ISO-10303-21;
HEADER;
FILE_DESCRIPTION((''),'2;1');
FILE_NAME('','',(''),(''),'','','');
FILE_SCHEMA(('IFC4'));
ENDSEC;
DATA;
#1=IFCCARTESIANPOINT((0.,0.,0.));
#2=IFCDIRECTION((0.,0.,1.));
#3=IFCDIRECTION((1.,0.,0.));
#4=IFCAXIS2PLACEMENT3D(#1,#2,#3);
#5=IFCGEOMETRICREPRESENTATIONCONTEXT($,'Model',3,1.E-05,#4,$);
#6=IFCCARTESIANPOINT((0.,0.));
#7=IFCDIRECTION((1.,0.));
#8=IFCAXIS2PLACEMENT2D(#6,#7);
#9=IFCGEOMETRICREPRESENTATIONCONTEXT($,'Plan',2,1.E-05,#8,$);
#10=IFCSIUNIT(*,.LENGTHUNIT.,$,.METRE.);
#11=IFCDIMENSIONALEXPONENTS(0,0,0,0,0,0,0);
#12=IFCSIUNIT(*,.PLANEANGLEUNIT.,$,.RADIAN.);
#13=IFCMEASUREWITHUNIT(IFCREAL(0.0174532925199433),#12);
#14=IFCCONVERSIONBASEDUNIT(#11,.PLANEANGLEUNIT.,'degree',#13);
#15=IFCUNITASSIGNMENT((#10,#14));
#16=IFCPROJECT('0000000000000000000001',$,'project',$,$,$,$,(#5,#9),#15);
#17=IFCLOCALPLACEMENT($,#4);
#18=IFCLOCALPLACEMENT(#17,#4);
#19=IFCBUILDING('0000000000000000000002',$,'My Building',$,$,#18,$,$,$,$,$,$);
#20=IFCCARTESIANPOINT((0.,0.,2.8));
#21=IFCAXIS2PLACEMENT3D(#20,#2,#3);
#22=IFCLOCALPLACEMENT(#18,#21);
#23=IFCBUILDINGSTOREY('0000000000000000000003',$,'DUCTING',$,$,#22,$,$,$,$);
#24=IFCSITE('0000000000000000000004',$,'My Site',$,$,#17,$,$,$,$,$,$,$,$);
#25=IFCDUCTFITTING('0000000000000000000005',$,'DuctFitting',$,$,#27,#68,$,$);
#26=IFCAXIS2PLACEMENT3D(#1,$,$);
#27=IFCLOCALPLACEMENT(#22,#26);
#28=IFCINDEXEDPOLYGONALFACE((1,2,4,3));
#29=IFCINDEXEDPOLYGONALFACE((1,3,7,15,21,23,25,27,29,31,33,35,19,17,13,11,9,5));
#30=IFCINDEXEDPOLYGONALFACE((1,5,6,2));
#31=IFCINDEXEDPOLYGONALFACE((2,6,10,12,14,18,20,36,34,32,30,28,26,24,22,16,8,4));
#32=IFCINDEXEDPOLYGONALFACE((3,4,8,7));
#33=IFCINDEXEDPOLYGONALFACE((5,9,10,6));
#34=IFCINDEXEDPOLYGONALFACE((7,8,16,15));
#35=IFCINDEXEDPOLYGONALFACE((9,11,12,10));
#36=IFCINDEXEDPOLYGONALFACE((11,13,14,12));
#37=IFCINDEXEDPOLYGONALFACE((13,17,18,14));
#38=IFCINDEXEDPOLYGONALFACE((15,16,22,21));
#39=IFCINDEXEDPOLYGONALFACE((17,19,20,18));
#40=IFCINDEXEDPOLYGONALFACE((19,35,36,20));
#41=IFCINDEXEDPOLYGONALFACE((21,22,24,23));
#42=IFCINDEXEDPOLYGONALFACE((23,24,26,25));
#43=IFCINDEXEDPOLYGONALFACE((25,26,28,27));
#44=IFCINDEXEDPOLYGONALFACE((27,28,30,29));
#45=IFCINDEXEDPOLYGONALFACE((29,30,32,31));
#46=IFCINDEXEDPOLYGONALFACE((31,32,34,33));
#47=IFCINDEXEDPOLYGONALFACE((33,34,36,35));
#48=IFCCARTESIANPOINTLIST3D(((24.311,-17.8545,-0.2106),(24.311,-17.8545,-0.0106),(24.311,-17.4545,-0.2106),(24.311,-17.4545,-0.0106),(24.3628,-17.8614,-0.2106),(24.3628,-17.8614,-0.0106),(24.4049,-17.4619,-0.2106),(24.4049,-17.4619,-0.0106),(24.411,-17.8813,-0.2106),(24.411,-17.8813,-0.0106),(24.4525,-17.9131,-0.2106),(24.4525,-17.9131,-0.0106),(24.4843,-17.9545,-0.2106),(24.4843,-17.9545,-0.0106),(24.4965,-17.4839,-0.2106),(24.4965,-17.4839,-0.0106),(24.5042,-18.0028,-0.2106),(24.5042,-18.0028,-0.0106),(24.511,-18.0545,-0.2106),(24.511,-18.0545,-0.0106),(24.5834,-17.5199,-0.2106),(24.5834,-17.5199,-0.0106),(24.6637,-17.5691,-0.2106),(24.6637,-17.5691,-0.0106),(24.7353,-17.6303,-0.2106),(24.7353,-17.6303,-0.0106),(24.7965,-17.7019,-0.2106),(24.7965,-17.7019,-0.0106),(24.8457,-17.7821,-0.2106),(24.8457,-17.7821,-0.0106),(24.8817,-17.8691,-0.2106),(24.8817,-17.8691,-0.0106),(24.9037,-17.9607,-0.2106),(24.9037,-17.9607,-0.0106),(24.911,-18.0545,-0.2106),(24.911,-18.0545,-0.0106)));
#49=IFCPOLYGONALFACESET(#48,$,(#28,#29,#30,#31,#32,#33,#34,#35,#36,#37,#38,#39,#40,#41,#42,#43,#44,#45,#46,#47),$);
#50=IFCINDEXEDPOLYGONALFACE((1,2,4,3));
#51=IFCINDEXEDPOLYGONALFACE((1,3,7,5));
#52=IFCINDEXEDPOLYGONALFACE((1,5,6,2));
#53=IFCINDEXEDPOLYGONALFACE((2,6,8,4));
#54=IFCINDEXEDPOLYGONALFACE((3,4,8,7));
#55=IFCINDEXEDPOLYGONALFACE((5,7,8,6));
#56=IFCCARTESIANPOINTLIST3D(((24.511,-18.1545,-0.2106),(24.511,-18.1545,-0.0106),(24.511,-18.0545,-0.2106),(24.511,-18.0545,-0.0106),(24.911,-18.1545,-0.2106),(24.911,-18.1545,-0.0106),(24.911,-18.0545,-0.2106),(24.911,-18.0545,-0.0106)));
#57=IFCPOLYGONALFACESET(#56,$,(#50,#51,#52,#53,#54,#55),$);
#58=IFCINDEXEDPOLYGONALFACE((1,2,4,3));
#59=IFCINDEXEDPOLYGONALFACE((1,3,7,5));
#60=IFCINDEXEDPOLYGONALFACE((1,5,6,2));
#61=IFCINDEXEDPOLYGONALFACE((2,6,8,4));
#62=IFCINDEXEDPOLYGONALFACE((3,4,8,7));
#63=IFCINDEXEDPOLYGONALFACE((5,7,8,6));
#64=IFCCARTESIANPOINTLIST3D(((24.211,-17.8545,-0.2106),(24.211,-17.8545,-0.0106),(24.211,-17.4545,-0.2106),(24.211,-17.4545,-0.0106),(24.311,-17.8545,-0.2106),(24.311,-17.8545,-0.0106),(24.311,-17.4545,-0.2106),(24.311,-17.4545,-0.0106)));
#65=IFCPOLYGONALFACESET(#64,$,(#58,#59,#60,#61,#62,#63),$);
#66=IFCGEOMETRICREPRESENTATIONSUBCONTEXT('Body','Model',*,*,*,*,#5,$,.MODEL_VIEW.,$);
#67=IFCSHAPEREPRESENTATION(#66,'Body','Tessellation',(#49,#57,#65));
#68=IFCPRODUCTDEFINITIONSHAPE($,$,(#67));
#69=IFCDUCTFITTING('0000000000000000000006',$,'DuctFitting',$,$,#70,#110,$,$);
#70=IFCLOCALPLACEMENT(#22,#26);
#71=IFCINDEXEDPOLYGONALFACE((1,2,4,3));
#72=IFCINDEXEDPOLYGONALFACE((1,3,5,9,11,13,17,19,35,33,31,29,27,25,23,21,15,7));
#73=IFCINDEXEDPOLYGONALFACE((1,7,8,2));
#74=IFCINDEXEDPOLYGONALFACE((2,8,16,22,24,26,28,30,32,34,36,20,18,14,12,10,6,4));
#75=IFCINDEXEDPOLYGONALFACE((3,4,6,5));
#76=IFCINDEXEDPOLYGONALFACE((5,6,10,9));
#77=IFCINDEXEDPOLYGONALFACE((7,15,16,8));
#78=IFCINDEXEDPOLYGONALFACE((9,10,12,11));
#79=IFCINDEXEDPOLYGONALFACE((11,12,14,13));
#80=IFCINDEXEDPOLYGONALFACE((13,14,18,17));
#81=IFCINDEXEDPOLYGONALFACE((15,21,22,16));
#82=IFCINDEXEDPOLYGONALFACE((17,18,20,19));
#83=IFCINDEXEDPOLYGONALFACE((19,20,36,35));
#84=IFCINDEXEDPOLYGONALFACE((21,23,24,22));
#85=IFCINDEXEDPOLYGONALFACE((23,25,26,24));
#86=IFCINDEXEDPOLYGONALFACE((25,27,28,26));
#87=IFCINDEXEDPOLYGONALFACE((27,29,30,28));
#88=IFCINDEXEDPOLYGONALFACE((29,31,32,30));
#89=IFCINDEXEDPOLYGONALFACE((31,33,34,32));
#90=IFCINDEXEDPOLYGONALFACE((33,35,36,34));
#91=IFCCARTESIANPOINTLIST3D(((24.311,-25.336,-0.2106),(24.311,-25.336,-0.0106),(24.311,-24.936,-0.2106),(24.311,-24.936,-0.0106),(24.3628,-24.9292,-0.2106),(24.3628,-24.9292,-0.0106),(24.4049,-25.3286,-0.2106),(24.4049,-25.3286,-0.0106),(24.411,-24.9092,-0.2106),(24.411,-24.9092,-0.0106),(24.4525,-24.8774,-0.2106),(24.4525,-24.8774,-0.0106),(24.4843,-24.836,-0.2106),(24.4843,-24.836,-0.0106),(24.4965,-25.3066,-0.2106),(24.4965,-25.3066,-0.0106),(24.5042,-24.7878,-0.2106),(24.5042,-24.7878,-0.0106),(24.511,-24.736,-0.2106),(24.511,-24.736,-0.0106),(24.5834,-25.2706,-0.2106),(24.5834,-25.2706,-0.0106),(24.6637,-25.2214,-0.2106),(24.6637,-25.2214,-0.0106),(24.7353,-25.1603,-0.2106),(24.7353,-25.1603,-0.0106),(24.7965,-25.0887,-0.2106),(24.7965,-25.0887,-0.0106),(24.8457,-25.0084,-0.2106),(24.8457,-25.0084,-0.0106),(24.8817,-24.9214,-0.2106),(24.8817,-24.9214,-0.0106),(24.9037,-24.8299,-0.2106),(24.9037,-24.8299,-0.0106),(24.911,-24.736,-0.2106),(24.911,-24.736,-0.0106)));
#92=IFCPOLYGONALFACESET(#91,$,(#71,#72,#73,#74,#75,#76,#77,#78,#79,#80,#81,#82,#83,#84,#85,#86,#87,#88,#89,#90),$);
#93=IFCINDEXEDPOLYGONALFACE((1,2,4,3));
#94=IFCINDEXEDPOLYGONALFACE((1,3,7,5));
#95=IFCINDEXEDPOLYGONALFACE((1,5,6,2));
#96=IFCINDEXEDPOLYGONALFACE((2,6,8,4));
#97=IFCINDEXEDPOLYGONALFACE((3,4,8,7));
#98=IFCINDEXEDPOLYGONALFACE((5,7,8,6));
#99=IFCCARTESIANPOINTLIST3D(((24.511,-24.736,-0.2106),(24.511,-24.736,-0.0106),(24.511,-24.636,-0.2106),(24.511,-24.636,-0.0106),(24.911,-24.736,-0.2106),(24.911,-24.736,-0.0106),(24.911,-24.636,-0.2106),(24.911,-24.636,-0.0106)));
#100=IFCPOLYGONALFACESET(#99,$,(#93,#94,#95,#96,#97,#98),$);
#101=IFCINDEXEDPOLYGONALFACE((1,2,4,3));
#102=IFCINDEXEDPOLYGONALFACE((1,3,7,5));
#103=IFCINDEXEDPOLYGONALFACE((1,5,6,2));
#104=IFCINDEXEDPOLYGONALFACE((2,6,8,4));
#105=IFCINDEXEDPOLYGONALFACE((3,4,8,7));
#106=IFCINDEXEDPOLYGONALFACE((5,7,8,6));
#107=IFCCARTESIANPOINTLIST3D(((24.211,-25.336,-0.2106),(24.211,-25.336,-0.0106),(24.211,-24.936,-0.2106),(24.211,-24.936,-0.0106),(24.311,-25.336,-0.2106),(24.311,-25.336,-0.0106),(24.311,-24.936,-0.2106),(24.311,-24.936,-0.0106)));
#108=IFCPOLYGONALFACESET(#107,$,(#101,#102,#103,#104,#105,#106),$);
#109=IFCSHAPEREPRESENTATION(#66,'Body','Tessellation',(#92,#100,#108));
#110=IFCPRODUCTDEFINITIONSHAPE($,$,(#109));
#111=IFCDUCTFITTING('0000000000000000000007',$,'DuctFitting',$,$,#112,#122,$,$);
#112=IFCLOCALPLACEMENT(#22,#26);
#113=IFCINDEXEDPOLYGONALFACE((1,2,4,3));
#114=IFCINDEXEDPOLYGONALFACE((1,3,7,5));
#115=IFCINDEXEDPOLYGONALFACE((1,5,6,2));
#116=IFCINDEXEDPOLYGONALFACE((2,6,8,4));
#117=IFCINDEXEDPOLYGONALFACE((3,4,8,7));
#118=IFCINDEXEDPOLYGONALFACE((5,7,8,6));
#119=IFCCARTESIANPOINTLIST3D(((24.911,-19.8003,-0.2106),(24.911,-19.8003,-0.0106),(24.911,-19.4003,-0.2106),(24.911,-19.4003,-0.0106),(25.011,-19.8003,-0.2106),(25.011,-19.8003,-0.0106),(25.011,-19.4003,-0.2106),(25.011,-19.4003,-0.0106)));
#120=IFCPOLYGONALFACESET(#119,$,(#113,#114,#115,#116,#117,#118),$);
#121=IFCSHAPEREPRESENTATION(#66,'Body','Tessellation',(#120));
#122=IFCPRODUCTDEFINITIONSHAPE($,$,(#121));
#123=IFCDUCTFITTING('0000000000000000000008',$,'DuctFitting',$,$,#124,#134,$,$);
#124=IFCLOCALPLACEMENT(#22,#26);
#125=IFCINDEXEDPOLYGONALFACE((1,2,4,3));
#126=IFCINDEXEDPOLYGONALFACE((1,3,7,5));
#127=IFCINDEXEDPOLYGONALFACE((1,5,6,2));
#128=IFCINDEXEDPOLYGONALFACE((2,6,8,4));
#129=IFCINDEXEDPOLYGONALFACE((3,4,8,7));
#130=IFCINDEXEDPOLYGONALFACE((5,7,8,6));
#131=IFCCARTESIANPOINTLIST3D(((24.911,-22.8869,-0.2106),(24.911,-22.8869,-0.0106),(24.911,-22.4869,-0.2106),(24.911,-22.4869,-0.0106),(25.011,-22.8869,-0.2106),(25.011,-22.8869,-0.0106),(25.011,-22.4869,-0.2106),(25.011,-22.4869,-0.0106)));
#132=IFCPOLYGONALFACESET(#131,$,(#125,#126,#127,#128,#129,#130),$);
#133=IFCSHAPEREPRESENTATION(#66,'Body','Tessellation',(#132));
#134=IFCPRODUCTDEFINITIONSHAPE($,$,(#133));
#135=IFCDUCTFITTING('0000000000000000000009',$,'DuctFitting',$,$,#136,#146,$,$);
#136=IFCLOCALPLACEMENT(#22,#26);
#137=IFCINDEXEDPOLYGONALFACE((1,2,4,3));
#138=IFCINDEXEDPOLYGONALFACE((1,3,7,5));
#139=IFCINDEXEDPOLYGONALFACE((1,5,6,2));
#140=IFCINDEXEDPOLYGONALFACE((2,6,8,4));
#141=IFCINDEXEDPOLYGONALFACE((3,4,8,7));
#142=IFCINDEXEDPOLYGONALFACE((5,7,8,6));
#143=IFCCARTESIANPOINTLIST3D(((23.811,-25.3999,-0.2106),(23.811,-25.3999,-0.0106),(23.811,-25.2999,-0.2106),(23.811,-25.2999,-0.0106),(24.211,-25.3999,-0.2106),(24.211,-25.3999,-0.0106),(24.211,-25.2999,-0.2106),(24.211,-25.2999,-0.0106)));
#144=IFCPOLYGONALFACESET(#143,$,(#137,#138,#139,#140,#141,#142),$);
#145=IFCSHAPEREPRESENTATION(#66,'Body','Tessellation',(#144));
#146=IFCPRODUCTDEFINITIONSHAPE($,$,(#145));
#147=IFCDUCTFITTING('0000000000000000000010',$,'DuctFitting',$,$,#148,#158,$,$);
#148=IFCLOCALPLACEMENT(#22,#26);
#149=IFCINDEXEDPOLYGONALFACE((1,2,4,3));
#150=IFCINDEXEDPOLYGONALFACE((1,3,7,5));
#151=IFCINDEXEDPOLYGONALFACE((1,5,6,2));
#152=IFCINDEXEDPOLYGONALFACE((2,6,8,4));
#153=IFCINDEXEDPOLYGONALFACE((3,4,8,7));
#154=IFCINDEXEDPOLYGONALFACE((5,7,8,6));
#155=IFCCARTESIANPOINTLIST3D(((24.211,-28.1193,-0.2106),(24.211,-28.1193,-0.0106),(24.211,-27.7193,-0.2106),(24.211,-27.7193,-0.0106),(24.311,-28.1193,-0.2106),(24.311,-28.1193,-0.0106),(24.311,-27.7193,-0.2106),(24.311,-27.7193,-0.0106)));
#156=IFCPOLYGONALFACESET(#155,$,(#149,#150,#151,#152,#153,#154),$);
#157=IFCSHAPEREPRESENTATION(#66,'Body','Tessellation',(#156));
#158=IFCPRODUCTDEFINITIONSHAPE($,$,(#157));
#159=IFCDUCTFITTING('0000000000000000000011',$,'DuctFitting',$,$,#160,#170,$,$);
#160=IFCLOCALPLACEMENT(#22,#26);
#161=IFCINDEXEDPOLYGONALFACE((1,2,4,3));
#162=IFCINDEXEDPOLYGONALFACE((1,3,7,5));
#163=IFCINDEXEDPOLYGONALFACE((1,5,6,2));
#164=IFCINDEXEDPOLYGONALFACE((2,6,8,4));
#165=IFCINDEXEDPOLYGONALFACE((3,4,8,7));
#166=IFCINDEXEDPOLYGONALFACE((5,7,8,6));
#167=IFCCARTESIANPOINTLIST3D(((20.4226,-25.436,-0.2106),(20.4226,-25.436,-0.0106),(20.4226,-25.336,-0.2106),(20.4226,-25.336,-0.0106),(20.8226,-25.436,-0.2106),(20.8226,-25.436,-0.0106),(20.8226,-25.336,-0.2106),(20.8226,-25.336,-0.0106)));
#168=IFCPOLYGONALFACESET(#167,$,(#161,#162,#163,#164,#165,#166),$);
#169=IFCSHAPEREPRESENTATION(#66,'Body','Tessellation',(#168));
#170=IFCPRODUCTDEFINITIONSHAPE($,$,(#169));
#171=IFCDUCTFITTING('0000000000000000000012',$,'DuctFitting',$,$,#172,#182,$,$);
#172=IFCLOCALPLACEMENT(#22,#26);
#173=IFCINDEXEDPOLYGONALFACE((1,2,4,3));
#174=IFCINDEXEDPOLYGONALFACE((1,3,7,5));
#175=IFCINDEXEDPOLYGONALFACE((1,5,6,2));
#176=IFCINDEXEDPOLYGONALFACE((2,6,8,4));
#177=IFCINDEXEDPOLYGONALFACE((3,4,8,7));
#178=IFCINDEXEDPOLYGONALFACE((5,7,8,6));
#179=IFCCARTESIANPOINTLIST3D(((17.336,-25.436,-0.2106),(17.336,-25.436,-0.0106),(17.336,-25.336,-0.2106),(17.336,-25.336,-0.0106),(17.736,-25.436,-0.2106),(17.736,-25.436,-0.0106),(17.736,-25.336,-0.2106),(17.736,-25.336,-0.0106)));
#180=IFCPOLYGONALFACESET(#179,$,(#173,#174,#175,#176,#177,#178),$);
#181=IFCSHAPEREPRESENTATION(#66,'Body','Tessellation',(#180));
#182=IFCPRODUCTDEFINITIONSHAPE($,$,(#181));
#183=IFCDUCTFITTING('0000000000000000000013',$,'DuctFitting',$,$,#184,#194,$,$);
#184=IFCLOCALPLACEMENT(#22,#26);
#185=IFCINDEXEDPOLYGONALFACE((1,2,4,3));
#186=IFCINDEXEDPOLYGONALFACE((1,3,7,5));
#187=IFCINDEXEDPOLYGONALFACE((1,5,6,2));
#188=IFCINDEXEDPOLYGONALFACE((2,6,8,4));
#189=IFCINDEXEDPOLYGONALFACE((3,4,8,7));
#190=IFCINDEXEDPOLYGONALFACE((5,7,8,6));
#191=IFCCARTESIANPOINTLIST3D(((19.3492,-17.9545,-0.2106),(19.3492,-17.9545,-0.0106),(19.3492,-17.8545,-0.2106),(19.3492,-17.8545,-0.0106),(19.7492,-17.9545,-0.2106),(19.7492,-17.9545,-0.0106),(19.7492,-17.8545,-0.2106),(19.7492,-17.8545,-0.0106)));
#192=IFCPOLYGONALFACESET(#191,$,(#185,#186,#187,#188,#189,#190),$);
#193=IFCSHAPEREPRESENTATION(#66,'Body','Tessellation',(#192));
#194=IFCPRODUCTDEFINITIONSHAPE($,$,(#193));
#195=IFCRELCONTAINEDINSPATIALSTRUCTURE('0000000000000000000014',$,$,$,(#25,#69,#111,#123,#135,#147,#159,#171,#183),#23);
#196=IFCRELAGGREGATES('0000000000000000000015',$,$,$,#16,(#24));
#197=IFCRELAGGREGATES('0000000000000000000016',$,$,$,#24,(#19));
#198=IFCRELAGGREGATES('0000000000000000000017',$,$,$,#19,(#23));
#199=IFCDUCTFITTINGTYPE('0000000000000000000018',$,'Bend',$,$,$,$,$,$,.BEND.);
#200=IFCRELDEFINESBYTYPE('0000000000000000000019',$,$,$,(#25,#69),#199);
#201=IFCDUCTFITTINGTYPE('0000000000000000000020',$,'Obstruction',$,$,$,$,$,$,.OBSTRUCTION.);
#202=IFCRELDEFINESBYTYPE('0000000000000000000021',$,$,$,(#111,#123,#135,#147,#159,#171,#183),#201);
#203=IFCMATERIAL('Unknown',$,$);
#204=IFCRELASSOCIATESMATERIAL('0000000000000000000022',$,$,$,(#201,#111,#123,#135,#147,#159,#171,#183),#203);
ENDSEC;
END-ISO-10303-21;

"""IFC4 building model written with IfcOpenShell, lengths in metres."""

from ifc_helpers import new_model, entity, si_unit, converted_unit, frame, origin_with_axes, origin_2d_with_axis, place, context, subcontext, project, spatial, line, arc, indexed_curve, rectangle, outline, extrude, source, transform, mapped, material, material_profile, profile_set, profile_usage, type_object, type_shapes, element, save


model = new_model("IFC4")

# Units and contexts
model_context = context("Model", 3, precision=1e-05, world=origin_with_axes())
plan_context = context("Plan", 2, precision=1e-05, world=origin_2d_with_axis())
body_context = subcontext(model_context, "Body", "Model", "MODEL_VIEW")
ifc_project = project(units=[si_unit("LENGTHUNIT", "METRE"), converted_unit("PLANEANGLEUNIT", "degree", entity("IfcReal", 0.0174532925199433), si_unit("PLANEANGLEUNIT", "RADIAN"), dimensions=[0, 0, 0, 0, 0, 0, 0])], contexts=[model_context, plan_context])

# Site, building, storey
site_placement = place(None, origin_with_axes())
site = spatial("IfcSite", under=ifc_project, at=site_placement, Name="My Site")
building_placement = place(site_placement, origin_with_axes())
building = spatial("IfcBuilding", under=site, at=building_placement, Name="My Building")
storey_placement = place(building_placement, frame((0.0, 0.0, 2.8), z_axis=(0.0, 0.0, 1.0), x_axis=(1.0, 0.0, 0.0)))
storey = spatial("IfcBuildingStorey", under=building, at=storey_placement, Name="DUCTING")

# Shared definitions
ifc_material = material(Name="Unknown")

# Duct fittings
duct_fitting_type_1 = type_object("IfcDuctFittingType", Name="Bend", PredefinedType="BEND")
shared_shape = source(origin_with_axes(), body_context, "Body", "SweptSolid", [
    extrude(outline(indexed_curve([(-0.2, 0.0), (-0.2586, -0.1414), (-0.4, -0.2), (-0.4, -0.6), (0.0243, -0.4243), (0.2, 0.0)], segments=[arc(1, 2, 3), line(3, 4), arc(4, 5, 6), line(6, 1)])), frame((0.0, -0.1, -0.1), z_axis=(0.0, -1.0, 0.0), x_axis=(1.0, 0.0, 0.0)), (0.0, 0.0, -1.0), 0.2),
    extrude(rectangle(XDim=0.4, YDim=0.2), origin_with_axes(), (0.0, 0.0, -1.0), 0.1),
    extrude(rectangle(XDim=0.4, YDim=0.2), frame((-0.4, 0.0, -0.5), z_axis=(-1.0, 0.0, 0.0), x_axis=(0.0, 0.0, -1.0)), (0.0, 0.0, 1.0), 0.1),
])
type_shapes(duct_fitting_type_1, [shared_shape])
for number, where, z_axis, x_axis, name in (
    (1, (24.711, -18.1545, -0.1106), (0.0, -1.0, 0.0), (1.0, 0.0, 0.0), "DuctFitting"),
    (2, (24.711, -24.636, -0.1106), (0.0, 1.0, 0.0), (1.0, 0.0, 0.0), "DuctFitting"),
):
    element("IfcDuctFitting", number, at=place(storey_placement, frame(where, z_axis=z_axis, x_axis=x_axis)), inside=storey, type_object=duct_fitting_type_1, Name=name, context=body_context, shape_type="MappedRepresentation", body=[
        mapped(shared_shape, transform((0.0, 0.0, 0.0), x_axis=(1.0, 0.0, 0.0), y_axis=(0.0, 1.0, 0.0), z_axis=(0.0, 0.0, 1.0), scale=1.0)),
    ])
ifc_material_profile_1 = material_profile(ifc_material, rectangle(XDim=0.4, YDim=0.2))
ifc_profile_set_1 = profile_set([ifc_material_profile_1])
ifc_profile_usage_1 = profile_usage(ifc_profile_set_1, cardinal=5)
duct_fitting_type_2 = type_object("IfcDuctFittingType", Name="Obstruction", PredefinedType="OBSTRUCTION", material=ifc_profile_set_1)
duct_fitting_1_placement = place(storey_placement, frame((24.911, -19.6003, -0.1106), z_axis=(1.0, 0.0, 0.0), x_axis=(0.0, 1.0, 0.0)))
element("IfcDuctFitting", 3, at=duct_fitting_1_placement, inside=storey, type_object=duct_fitting_type_2, material=ifc_profile_usage_1, Name="DuctFitting", context=body_context, shape_type="SweptSolid", body=[
    extrude(rectangle(XDim=0.4, YDim=0.2), origin_with_axes(), (0.0, 0.0, 1.0), 0.1),
])
ifc_profile_usage_2 = profile_usage(ifc_profile_set_1, cardinal=5)
duct_fitting_2_placement = place(storey_placement, frame((24.911, -22.6869, -0.1106), z_axis=(1.0, 0.0, 0.0), x_axis=(0.0, 1.0, 0.0)))
element("IfcDuctFitting", 4, at=duct_fitting_2_placement, inside=storey, type_object=duct_fitting_type_2, material=ifc_profile_usage_2, Name="DuctFitting", context=body_context, shape_type="SweptSolid", body=[
    extrude(rectangle(XDim=0.4, YDim=0.2), origin_with_axes(), (0.0, 0.0, 1.0), 0.1),
])
ifc_profile_usage_3 = profile_usage(ifc_profile_set_1, cardinal=5)
duct_fitting_3_placement = place(storey_placement, frame((24.011, -25.3999, -0.1106), z_axis=(0.0, 1.0, 0.0), x_axis=(-1.0, 0.0, 0.0)))
element("IfcDuctFitting", 5, at=duct_fitting_3_placement, inside=storey, type_object=duct_fitting_type_2, material=ifc_profile_usage_3, Name="DuctFitting", context=body_context, shape_type="SweptSolid", body=[
    extrude(rectangle(XDim=0.4, YDim=0.2), origin_with_axes(), (0.0, 0.0, 1.0), 0.1),
])
ifc_profile_usage_4 = profile_usage(ifc_profile_set_1, cardinal=5)
duct_fitting_4_placement = place(storey_placement, frame((24.211, -27.9193, -0.1106), z_axis=(1.0, 0.0, 0.0), x_axis=(0.0, 1.0, 0.0)))
element("IfcDuctFitting", 6, at=duct_fitting_4_placement, inside=storey, type_object=duct_fitting_type_2, material=ifc_profile_usage_4, Name="DuctFitting", context=body_context, shape_type="SweptSolid", body=[
    extrude(rectangle(XDim=0.4, YDim=0.2), origin_with_axes(), (0.0, 0.0, 1.0), 0.1),
])
ifc_profile_usage_5 = profile_usage(ifc_profile_set_1, cardinal=5)
duct_fitting_5_placement = place(storey_placement, frame((20.6226, -25.436, -0.1106), z_axis=(0.0, 1.0, 0.0), x_axis=(-1.0, 0.0, 0.0)))
element("IfcDuctFitting", 7, at=duct_fitting_5_placement, inside=storey, type_object=duct_fitting_type_2, material=ifc_profile_usage_5, Name="DuctFitting", context=body_context, shape_type="SweptSolid", body=[
    extrude(rectangle(XDim=0.4, YDim=0.2), origin_with_axes(), (0.0, 0.0, 1.0), 0.1),
])
ifc_profile_usage_6 = profile_usage(ifc_profile_set_1, cardinal=5)
duct_fitting_6_placement = place(storey_placement, frame((17.536, -25.436, -0.1106), z_axis=(0.0, 1.0, 0.0), x_axis=(-1.0, 0.0, 0.0)))
element("IfcDuctFitting", 8, at=duct_fitting_6_placement, inside=storey, type_object=duct_fitting_type_2, material=ifc_profile_usage_6, Name="DuctFitting", context=body_context, shape_type="SweptSolid", body=[
    extrude(rectangle(XDim=0.4, YDim=0.2), origin_with_axes(), (0.0, 0.0, 1.0), 0.1),
])
ifc_profile_usage_7 = profile_usage(ifc_profile_set_1, cardinal=5)
duct_fitting_7_placement = place(storey_placement, frame((19.5492, -17.9545, -0.1106), z_axis=(0.0, 1.0, 0.0), x_axis=(-1.0, 0.0, 0.0)))
element("IfcDuctFitting", 9, at=duct_fitting_7_placement, inside=storey, type_object=duct_fitting_type_2, material=ifc_profile_usage_7, Name="DuctFitting", context=body_context, shape_type="SweptSolid", body=[
    extrude(rectangle(XDim=0.4, YDim=0.2), origin_with_axes(), (0.0, 0.0, 1.0), 0.1),
])

save(model, "model.ifc")
